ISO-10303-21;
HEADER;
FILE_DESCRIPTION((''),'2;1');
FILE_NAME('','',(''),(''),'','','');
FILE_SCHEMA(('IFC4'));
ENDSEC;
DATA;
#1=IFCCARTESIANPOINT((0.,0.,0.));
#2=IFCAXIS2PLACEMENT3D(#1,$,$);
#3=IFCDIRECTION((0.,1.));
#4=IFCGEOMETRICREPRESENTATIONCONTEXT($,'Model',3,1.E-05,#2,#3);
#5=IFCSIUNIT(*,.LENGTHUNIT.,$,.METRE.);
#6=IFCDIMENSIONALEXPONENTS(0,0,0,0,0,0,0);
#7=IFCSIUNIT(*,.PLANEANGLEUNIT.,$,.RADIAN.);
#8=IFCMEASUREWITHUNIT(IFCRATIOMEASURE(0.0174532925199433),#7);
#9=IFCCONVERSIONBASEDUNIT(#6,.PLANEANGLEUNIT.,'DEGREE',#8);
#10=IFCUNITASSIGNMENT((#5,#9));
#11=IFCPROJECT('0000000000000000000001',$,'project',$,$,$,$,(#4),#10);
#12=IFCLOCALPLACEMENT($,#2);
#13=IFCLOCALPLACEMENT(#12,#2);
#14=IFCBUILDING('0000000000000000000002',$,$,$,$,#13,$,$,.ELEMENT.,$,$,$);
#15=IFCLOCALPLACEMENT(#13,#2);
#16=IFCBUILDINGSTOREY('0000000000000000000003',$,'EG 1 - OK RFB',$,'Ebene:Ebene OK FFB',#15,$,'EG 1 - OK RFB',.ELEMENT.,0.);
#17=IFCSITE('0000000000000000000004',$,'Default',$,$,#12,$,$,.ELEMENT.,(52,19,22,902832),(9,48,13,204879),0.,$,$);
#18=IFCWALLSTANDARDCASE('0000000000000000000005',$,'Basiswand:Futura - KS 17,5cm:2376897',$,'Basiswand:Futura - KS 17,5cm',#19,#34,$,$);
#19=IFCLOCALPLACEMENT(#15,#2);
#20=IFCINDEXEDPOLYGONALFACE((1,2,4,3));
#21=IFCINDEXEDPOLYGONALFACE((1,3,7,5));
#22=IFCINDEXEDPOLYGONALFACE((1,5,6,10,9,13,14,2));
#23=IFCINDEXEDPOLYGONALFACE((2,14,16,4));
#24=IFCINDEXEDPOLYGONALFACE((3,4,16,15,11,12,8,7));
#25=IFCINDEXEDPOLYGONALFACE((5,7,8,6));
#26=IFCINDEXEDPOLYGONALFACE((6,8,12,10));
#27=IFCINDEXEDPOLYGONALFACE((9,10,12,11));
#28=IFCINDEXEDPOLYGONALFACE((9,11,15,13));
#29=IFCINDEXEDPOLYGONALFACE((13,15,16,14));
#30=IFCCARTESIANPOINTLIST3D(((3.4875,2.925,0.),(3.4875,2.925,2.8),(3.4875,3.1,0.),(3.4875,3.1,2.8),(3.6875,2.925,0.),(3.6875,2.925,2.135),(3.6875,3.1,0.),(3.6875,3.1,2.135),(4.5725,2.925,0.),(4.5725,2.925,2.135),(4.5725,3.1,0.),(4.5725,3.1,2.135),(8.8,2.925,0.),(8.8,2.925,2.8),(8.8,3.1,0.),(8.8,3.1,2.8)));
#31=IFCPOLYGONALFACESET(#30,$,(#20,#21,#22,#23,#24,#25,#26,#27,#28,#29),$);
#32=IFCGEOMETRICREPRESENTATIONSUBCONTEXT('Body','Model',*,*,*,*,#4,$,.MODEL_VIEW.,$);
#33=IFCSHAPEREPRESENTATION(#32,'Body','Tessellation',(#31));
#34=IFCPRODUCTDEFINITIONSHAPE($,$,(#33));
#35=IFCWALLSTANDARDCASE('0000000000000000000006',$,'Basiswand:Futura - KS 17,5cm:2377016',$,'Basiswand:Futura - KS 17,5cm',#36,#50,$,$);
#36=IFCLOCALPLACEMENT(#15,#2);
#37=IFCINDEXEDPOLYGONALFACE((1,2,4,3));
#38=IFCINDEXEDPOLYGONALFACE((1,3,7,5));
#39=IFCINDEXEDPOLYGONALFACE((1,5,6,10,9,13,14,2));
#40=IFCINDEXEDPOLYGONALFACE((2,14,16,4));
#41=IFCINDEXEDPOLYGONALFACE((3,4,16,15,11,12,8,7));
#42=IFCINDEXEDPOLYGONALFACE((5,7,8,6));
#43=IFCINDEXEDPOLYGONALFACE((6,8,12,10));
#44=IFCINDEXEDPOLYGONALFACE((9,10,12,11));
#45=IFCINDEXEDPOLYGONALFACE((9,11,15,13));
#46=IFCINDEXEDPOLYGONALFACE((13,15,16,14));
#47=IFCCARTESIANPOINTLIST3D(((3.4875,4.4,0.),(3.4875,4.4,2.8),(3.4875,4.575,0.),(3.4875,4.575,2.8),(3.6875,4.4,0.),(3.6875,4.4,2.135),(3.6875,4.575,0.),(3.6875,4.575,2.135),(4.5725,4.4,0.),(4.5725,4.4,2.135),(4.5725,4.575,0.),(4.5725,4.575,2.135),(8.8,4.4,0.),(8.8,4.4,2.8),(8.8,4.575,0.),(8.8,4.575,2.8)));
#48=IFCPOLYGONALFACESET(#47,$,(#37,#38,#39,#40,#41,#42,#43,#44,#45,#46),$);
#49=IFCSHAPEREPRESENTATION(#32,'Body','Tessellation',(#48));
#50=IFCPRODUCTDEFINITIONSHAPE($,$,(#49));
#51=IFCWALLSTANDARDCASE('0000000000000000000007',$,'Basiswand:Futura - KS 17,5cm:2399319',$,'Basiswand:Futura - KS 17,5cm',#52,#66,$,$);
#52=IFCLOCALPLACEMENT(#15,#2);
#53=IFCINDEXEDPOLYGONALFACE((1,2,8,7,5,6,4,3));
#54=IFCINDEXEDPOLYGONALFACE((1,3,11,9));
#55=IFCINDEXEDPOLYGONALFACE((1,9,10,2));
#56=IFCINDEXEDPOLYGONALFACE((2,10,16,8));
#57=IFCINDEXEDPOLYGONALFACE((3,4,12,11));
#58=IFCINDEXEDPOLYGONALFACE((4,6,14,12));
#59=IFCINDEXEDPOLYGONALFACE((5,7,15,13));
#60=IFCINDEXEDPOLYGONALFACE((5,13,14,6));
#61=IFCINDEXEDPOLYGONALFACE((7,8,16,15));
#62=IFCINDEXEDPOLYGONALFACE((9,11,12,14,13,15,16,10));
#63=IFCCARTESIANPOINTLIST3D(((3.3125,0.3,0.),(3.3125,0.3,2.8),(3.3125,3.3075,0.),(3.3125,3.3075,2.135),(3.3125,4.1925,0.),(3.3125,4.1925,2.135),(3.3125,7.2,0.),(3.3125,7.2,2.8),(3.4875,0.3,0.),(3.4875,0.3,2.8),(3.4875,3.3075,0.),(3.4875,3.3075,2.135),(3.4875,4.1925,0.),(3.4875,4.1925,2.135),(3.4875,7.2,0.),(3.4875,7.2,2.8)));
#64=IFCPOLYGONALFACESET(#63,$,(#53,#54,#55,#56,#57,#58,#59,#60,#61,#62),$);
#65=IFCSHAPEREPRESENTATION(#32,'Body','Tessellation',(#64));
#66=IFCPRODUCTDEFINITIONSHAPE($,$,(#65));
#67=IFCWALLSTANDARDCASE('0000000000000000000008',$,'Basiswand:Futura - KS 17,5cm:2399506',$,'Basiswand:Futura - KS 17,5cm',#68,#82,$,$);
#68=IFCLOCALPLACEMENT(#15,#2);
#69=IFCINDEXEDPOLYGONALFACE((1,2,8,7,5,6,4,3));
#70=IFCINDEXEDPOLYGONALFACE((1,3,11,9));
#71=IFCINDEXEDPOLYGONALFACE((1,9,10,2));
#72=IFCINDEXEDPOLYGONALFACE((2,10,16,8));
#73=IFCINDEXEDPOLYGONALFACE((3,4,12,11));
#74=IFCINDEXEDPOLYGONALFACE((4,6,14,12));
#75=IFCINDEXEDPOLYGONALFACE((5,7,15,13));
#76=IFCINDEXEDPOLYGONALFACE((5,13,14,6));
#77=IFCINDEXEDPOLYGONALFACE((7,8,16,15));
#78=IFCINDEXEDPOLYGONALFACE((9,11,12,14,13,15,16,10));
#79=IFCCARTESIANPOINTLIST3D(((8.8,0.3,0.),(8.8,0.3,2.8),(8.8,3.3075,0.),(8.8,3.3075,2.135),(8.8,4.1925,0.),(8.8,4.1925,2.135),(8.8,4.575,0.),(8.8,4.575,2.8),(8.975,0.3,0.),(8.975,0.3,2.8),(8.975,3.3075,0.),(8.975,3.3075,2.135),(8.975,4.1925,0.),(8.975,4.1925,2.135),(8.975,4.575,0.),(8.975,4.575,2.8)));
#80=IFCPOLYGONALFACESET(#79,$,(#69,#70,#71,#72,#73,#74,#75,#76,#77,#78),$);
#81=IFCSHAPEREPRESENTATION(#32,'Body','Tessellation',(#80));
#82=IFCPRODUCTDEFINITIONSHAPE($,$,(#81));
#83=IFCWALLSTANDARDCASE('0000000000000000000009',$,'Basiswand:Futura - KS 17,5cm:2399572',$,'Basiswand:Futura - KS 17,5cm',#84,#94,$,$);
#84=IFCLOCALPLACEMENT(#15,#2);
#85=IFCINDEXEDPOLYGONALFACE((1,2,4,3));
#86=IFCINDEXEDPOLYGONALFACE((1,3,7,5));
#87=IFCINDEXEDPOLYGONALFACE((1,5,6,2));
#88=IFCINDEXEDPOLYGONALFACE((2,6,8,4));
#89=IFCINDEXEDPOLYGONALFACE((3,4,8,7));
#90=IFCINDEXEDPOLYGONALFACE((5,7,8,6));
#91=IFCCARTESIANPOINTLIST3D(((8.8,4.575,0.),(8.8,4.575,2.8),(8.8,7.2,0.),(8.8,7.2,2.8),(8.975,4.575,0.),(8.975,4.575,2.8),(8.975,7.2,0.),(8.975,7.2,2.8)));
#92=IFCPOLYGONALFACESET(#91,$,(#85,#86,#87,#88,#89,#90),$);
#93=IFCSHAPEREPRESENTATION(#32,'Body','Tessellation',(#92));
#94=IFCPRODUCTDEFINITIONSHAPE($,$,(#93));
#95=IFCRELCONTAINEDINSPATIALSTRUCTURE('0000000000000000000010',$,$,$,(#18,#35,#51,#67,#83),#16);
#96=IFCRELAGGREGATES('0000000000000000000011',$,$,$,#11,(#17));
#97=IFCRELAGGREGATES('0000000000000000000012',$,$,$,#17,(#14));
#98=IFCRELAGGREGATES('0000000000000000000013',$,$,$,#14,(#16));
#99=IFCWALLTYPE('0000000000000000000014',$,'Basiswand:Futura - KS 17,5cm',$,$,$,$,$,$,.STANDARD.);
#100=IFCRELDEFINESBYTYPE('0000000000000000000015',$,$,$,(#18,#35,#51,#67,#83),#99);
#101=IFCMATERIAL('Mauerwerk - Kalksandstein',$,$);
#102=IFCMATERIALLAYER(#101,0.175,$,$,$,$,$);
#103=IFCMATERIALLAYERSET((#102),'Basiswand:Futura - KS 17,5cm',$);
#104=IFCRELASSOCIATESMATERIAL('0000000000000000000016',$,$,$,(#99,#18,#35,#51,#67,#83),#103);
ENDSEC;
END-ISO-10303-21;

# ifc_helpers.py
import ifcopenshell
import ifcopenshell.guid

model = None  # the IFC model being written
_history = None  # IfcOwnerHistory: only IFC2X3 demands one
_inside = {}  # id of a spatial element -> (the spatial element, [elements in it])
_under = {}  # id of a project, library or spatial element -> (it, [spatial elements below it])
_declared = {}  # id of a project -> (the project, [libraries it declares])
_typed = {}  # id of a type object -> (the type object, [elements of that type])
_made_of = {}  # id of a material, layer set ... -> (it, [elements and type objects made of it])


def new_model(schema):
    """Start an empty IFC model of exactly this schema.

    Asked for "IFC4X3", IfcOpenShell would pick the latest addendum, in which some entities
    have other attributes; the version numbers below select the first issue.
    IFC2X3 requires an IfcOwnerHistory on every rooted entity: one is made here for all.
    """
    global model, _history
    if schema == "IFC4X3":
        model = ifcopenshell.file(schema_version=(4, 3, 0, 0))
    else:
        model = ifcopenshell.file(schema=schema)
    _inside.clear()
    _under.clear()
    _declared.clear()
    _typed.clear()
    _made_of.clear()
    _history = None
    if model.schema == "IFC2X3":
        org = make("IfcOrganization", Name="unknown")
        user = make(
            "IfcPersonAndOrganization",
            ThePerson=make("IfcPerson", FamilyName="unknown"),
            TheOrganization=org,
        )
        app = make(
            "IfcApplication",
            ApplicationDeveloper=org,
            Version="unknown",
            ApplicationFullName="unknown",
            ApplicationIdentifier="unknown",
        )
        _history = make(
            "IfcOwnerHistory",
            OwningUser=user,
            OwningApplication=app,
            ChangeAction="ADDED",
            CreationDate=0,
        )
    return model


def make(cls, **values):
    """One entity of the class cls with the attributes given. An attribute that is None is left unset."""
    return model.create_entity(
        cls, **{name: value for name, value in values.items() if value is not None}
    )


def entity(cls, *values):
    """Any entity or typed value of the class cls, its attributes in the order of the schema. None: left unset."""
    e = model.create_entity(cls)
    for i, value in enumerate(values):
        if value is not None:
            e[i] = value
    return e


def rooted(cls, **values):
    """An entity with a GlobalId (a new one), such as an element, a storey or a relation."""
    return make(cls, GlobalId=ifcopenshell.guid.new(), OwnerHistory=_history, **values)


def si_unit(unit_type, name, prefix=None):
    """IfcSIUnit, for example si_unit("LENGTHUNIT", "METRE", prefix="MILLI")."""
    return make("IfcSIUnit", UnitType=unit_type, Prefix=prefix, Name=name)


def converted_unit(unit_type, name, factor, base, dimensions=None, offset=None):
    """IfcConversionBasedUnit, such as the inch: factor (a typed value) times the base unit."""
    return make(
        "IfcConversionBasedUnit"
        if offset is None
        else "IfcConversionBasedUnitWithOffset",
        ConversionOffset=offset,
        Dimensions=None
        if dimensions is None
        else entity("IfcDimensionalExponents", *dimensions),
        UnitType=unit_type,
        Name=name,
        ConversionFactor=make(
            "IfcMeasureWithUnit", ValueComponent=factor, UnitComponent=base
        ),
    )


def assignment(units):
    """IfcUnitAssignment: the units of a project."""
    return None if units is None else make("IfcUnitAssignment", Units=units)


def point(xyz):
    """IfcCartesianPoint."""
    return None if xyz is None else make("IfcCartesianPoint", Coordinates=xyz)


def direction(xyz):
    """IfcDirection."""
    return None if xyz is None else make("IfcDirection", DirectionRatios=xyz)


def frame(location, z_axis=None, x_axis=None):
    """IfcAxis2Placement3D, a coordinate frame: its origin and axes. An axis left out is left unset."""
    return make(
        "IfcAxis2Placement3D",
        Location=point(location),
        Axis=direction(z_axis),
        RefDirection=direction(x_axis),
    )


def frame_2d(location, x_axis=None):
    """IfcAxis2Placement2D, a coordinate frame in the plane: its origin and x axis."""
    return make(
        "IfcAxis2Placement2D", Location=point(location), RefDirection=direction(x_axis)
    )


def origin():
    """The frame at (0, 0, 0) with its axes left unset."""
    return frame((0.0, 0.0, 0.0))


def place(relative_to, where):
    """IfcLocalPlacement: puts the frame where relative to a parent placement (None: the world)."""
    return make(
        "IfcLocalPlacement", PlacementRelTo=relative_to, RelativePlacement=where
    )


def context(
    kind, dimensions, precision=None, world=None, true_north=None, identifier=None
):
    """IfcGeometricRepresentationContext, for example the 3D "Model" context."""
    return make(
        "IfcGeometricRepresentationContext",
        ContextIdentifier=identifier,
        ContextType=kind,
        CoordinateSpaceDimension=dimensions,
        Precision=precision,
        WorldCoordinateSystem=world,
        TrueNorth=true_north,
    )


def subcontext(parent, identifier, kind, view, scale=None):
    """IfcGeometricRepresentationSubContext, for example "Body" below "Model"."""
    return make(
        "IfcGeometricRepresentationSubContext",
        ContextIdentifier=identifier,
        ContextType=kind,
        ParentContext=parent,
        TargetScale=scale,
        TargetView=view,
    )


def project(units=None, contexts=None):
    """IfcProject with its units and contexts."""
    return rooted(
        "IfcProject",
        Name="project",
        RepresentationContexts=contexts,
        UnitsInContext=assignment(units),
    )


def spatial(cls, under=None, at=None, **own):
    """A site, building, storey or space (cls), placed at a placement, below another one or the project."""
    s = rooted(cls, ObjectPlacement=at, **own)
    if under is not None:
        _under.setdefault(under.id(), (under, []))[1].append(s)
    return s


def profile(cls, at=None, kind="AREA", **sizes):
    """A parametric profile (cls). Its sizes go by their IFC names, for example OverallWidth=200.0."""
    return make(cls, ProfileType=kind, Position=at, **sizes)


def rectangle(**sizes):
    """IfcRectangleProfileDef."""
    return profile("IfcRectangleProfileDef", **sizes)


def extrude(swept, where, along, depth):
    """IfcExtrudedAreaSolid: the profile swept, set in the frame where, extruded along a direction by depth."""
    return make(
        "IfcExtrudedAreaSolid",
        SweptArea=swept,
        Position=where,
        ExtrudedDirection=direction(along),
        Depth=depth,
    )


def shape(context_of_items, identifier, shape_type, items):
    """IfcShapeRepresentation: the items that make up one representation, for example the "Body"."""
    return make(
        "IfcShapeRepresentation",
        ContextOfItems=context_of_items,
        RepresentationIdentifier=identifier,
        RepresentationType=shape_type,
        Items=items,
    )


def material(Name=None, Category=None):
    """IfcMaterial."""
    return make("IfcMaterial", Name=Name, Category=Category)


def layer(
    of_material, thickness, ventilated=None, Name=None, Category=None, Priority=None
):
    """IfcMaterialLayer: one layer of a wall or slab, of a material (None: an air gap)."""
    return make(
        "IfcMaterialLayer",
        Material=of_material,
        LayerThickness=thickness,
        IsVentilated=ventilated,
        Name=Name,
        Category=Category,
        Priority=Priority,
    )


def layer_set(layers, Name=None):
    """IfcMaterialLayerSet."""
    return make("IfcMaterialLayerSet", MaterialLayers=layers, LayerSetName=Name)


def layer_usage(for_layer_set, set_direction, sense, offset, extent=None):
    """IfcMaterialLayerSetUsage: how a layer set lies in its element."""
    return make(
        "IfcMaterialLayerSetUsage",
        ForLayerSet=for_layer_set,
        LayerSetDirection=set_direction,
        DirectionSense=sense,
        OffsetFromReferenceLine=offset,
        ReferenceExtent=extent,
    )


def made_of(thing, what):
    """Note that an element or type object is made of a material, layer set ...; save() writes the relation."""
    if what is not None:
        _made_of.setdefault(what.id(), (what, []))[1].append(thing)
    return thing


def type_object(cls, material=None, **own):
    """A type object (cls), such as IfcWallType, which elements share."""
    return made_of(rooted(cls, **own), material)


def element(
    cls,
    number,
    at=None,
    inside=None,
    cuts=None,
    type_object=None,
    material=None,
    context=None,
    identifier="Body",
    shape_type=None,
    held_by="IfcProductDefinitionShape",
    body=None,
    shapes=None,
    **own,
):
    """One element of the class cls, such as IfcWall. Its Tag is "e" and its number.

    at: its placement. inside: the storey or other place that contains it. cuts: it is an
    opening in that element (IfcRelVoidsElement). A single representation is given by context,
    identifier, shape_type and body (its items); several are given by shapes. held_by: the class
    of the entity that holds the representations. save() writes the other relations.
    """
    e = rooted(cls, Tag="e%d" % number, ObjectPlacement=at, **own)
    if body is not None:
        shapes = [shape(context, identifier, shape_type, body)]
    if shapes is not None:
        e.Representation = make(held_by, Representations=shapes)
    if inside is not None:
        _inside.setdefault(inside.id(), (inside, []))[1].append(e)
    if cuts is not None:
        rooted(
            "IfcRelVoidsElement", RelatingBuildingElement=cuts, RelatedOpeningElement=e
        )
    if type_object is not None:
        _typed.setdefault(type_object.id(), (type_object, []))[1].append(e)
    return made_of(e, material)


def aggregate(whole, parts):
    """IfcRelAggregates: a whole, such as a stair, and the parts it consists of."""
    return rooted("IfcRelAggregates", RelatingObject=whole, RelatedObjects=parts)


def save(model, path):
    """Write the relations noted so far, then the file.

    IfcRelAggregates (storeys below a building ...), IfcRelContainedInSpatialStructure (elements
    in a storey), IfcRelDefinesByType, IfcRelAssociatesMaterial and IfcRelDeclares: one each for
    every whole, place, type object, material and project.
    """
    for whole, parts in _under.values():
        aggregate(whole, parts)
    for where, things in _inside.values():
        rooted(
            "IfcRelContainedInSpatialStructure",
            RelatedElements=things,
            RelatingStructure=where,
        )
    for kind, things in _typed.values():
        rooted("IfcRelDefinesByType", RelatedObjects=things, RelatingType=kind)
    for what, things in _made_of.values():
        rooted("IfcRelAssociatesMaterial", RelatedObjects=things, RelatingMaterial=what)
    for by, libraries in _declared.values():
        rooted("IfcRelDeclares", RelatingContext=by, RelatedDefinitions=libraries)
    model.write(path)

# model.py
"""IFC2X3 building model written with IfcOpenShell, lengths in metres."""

from ifc_helpers import new_model, entity, si_unit, converted_unit, direction, frame, frame_2d, origin, place, context, subcontext, project, spatial, rectangle, extrude, material, layer, layer_set, layer_usage, type_object, element, save


model = new_model("IFC2X3")

# Units and contexts
model_context = context("Model", 3, precision=1e-05, world=origin(), true_north=direction((0.0, 1.0)))
body_context = subcontext(model_context, "Body", "Model", "MODEL_VIEW")
ifc_project = project(units=[si_unit("LENGTHUNIT", "METRE"), converted_unit("PLANEANGLEUNIT", "DEGREE", entity("IfcRatioMeasure", 0.0174532925199433), si_unit("PLANEANGLEUNIT", "RADIAN"), dimensions=[0, 0, 0, 0, 0, 0, 0])], contexts=[model_context])

# Site, building, storey
site_placement = place(None, frame((0.0, 0.0, 0.0)))
site = spatial("IfcSite", under=ifc_project, at=site_placement, Name="Default", CompositionType="ELEMENT", RefLatitude=(52, 19, 22, 902832), RefLongitude=(9, 48, 13, 204879), RefElevation=0.0)
building_placement = place(site_placement, origin())
building = spatial("IfcBuilding", under=site, at=building_placement, CompositionType="ELEMENT")
storey_placement = place(building_placement, origin())
storey = spatial("IfcBuildingStorey", under=building, at=storey_placement, Name="EG 1 - OK RFB", ObjectType="Ebene:Ebene OK FFB", LongName="EG 1 - OK RFB", CompositionType="ELEMENT", Elevation=0.0)

# Walls, openings
ifc_material_1 = material(Name="Mauerwerk - Kalksandstein")
ifc_layer = layer(ifc_material_1, 0.175)
ifc_layer_set = layer_set([ifc_layer], Name="Basiswand:Futura - KS 17,5cm")
ifc_layer_usage_1 = layer_usage(ifc_layer_set, "AXIS2", "NEGATIVE", 0.0875)
wall_type = type_object("IfcWallType", Name="Basiswand:Futura - KS 17,5cm", PredefinedType="STANDARD", material=ifc_layer_set)
wall_1_placement = place(storey_placement, frame((3.4875, 3.0125, 0.0)))
wall_1 = element("IfcWallStandardCase", 1, at=wall_1_placement, inside=storey, type_object=wall_type, material=ifc_layer_usage_1, Name="Basiswand:Futura - KS 17,5cm:2376897", ObjectType="Basiswand:Futura - KS 17,5cm", context=body_context, shape_type="SweptSolid", body=[
    extrude(rectangle(XDim=5.3125, YDim=0.175, at=frame_2d((2.6562, 0.0), x_axis=(-1.0, 0.0))), origin(), (0.0, 0.0, 1.0), 2.8),
])
opening_1_placement = place(wall_1_placement, frame((1.085, 0.0875, -0.18)))
element("IfcOpeningElement", 2, at=opening_1_placement, cuts=wall_1, ObjectType="Opening", context=body_context, shape_type="SweptSolid", body=[
    extrude(rectangle(XDim=2.315, YDim=0.885, at=frame_2d((1.1575, 0.4425), x_axis=(-1.0, 0.0))), frame((0.0, 0.0, 0.0), z_axis=(0.0, -1.0, 0.0), x_axis=(0.0, 0.0, 1.0)), (0.0, 0.0, 1.0), 0.175),
])
ifc_layer_usage_2 = layer_usage(ifc_layer_set, "AXIS2", "NEGATIVE", 0.0875)
wall_2_placement = place(storey_placement, frame((3.4875, 4.4875, 0.0)))
wall_2 = element("IfcWallStandardCase", 3, at=wall_2_placement, inside=storey, type_object=wall_type, material=ifc_layer_usage_2, Name="Basiswand:Futura - KS 17,5cm:2377016", ObjectType="Basiswand:Futura - KS 17,5cm", context=body_context, shape_type="SweptSolid", body=[
    extrude(rectangle(XDim=5.3125, YDim=0.175, at=frame_2d((2.6562, 0.0), x_axis=(-1.0, 0.0))), origin(), (0.0, 0.0, 1.0), 2.8),
])
opening_2_placement = place(wall_2_placement, frame((1.085, 0.0875, -0.18)))
element("IfcOpeningElement", 4, at=opening_2_placement, cuts=wall_2, ObjectType="Opening", context=body_context, shape_type="SweptSolid", body=[
    extrude(rectangle(XDim=2.315, YDim=0.885, at=frame_2d((1.1575, 0.4425), x_axis=(-1.0, 0.0))), frame((0.0, 0.0, 0.0), z_axis=(0.0, -1.0, 0.0), x_axis=(0.0, 0.0, 1.0)), (0.0, 0.0, 1.0), 0.175),
])
ifc_layer_usage_3 = layer_usage(ifc_layer_set, "AXIS2", "NEGATIVE", 0.0875)
wall_3_placement = place(storey_placement, frame((3.4, 0.3, 0.0), z_axis=(0.0, 0.0, 1.0), x_axis=(0.0, 1.0, 0.0)))
wall_3 = element("IfcWallStandardCase", 5, at=wall_3_placement, inside=storey, type_object=wall_type, material=ifc_layer_usage_3, Name="Basiswand:Futura - KS 17,5cm:2399319", ObjectType="Basiswand:Futura - KS 17,5cm", context=body_context, shape_type="SweptSolid", body=[
    extrude(rectangle(XDim=6.9, YDim=0.175, at=frame_2d((3.45, 0.0), x_axis=(-1.0, 0.0))), origin(), (0.0, 0.0, 1.0), 2.8),
])
opening_3_placement = place(wall_3_placement, frame((3.8925, 0.0875, -0.18)))
element("IfcOpeningElement", 6, at=opening_3_placement, cuts=wall_3, ObjectType="Opening", context=body_context, shape_type="SweptSolid", body=[
    extrude(rectangle(XDim=2.315, YDim=0.885, at=frame_2d((1.1575, 0.4425), x_axis=(-1.0, 0.0))), frame((0.0, 0.0, 0.0), z_axis=(0.0, -1.0, 0.0), x_axis=(0.0, 0.0, 1.0)), (0.0, 0.0, 1.0), 0.175),
])
ifc_layer_usage_4 = layer_usage(ifc_layer_set, "AXIS2", "NEGATIVE", 0.0875)
wall_4_placement = place(storey_placement, frame((8.8875, 0.3, 0.0), z_axis=(0.0, 0.0, 1.0), x_axis=(0.0, 1.0, 0.0)))
wall_4 = element("IfcWallStandardCase", 7, at=wall_4_placement, inside=storey, type_object=wall_type, material=ifc_layer_usage_4, Name="Basiswand:Futura - KS 17,5cm:2399506", ObjectType="Basiswand:Futura - KS 17,5cm", context=body_context, shape_type="SweptSolid", body=[
    extrude(rectangle(XDim=4.275, YDim=0.175, at=frame_2d((2.1375, 0.0), x_axis=(-1.0, 0.0))), origin(), (0.0, 0.0, 1.0), 2.8),
])
opening_4_placement = place(wall_4_placement, frame((3.8925, 0.0875, 0.0)))
element("IfcOpeningElement", 8, at=opening_4_placement, cuts=wall_4, ObjectType="Opening", context=body_context, shape_type="SweptSolid", body=[
    extrude(rectangle(XDim=2.135, YDim=0.885, at=frame_2d((1.0675, 0.4425), x_axis=(-1.0, 0.0))), frame((0.0, 0.0, 0.0), z_axis=(0.0, -1.0, 0.0), x_axis=(0.0, 0.0, 1.0)), (0.0, 0.0, 1.0), 0.175),
])

# Wall
ifc_layer_usage_5 = layer_usage(ifc_layer_set, "AXIS2", "NEGATIVE", 0.0875)
wall_5_placement = place(storey_placement, frame((8.8875, 4.575, 0.0), z_axis=(0.0, 0.0, 1.0), x_axis=(0.0, 1.0, 0.0)))
element("IfcWallStandardCase", 9, at=wall_5_placement, inside=storey, type_object=wall_type, material=ifc_layer_usage_5, Name="Basiswand:Futura - KS 17,5cm:2399572", ObjectType="Basiswand:Futura - KS 17,5cm", context=body_context, shape_type="SweptSolid", body=[
    extrude(rectangle(XDim=2.625, YDim=0.175, at=frame_2d((1.3125, 0.0), x_axis=(-1.0, 0.0))), origin(), (0.0, 0.0, 1.0), 2.8),
])

save(model, "model.ifc")
